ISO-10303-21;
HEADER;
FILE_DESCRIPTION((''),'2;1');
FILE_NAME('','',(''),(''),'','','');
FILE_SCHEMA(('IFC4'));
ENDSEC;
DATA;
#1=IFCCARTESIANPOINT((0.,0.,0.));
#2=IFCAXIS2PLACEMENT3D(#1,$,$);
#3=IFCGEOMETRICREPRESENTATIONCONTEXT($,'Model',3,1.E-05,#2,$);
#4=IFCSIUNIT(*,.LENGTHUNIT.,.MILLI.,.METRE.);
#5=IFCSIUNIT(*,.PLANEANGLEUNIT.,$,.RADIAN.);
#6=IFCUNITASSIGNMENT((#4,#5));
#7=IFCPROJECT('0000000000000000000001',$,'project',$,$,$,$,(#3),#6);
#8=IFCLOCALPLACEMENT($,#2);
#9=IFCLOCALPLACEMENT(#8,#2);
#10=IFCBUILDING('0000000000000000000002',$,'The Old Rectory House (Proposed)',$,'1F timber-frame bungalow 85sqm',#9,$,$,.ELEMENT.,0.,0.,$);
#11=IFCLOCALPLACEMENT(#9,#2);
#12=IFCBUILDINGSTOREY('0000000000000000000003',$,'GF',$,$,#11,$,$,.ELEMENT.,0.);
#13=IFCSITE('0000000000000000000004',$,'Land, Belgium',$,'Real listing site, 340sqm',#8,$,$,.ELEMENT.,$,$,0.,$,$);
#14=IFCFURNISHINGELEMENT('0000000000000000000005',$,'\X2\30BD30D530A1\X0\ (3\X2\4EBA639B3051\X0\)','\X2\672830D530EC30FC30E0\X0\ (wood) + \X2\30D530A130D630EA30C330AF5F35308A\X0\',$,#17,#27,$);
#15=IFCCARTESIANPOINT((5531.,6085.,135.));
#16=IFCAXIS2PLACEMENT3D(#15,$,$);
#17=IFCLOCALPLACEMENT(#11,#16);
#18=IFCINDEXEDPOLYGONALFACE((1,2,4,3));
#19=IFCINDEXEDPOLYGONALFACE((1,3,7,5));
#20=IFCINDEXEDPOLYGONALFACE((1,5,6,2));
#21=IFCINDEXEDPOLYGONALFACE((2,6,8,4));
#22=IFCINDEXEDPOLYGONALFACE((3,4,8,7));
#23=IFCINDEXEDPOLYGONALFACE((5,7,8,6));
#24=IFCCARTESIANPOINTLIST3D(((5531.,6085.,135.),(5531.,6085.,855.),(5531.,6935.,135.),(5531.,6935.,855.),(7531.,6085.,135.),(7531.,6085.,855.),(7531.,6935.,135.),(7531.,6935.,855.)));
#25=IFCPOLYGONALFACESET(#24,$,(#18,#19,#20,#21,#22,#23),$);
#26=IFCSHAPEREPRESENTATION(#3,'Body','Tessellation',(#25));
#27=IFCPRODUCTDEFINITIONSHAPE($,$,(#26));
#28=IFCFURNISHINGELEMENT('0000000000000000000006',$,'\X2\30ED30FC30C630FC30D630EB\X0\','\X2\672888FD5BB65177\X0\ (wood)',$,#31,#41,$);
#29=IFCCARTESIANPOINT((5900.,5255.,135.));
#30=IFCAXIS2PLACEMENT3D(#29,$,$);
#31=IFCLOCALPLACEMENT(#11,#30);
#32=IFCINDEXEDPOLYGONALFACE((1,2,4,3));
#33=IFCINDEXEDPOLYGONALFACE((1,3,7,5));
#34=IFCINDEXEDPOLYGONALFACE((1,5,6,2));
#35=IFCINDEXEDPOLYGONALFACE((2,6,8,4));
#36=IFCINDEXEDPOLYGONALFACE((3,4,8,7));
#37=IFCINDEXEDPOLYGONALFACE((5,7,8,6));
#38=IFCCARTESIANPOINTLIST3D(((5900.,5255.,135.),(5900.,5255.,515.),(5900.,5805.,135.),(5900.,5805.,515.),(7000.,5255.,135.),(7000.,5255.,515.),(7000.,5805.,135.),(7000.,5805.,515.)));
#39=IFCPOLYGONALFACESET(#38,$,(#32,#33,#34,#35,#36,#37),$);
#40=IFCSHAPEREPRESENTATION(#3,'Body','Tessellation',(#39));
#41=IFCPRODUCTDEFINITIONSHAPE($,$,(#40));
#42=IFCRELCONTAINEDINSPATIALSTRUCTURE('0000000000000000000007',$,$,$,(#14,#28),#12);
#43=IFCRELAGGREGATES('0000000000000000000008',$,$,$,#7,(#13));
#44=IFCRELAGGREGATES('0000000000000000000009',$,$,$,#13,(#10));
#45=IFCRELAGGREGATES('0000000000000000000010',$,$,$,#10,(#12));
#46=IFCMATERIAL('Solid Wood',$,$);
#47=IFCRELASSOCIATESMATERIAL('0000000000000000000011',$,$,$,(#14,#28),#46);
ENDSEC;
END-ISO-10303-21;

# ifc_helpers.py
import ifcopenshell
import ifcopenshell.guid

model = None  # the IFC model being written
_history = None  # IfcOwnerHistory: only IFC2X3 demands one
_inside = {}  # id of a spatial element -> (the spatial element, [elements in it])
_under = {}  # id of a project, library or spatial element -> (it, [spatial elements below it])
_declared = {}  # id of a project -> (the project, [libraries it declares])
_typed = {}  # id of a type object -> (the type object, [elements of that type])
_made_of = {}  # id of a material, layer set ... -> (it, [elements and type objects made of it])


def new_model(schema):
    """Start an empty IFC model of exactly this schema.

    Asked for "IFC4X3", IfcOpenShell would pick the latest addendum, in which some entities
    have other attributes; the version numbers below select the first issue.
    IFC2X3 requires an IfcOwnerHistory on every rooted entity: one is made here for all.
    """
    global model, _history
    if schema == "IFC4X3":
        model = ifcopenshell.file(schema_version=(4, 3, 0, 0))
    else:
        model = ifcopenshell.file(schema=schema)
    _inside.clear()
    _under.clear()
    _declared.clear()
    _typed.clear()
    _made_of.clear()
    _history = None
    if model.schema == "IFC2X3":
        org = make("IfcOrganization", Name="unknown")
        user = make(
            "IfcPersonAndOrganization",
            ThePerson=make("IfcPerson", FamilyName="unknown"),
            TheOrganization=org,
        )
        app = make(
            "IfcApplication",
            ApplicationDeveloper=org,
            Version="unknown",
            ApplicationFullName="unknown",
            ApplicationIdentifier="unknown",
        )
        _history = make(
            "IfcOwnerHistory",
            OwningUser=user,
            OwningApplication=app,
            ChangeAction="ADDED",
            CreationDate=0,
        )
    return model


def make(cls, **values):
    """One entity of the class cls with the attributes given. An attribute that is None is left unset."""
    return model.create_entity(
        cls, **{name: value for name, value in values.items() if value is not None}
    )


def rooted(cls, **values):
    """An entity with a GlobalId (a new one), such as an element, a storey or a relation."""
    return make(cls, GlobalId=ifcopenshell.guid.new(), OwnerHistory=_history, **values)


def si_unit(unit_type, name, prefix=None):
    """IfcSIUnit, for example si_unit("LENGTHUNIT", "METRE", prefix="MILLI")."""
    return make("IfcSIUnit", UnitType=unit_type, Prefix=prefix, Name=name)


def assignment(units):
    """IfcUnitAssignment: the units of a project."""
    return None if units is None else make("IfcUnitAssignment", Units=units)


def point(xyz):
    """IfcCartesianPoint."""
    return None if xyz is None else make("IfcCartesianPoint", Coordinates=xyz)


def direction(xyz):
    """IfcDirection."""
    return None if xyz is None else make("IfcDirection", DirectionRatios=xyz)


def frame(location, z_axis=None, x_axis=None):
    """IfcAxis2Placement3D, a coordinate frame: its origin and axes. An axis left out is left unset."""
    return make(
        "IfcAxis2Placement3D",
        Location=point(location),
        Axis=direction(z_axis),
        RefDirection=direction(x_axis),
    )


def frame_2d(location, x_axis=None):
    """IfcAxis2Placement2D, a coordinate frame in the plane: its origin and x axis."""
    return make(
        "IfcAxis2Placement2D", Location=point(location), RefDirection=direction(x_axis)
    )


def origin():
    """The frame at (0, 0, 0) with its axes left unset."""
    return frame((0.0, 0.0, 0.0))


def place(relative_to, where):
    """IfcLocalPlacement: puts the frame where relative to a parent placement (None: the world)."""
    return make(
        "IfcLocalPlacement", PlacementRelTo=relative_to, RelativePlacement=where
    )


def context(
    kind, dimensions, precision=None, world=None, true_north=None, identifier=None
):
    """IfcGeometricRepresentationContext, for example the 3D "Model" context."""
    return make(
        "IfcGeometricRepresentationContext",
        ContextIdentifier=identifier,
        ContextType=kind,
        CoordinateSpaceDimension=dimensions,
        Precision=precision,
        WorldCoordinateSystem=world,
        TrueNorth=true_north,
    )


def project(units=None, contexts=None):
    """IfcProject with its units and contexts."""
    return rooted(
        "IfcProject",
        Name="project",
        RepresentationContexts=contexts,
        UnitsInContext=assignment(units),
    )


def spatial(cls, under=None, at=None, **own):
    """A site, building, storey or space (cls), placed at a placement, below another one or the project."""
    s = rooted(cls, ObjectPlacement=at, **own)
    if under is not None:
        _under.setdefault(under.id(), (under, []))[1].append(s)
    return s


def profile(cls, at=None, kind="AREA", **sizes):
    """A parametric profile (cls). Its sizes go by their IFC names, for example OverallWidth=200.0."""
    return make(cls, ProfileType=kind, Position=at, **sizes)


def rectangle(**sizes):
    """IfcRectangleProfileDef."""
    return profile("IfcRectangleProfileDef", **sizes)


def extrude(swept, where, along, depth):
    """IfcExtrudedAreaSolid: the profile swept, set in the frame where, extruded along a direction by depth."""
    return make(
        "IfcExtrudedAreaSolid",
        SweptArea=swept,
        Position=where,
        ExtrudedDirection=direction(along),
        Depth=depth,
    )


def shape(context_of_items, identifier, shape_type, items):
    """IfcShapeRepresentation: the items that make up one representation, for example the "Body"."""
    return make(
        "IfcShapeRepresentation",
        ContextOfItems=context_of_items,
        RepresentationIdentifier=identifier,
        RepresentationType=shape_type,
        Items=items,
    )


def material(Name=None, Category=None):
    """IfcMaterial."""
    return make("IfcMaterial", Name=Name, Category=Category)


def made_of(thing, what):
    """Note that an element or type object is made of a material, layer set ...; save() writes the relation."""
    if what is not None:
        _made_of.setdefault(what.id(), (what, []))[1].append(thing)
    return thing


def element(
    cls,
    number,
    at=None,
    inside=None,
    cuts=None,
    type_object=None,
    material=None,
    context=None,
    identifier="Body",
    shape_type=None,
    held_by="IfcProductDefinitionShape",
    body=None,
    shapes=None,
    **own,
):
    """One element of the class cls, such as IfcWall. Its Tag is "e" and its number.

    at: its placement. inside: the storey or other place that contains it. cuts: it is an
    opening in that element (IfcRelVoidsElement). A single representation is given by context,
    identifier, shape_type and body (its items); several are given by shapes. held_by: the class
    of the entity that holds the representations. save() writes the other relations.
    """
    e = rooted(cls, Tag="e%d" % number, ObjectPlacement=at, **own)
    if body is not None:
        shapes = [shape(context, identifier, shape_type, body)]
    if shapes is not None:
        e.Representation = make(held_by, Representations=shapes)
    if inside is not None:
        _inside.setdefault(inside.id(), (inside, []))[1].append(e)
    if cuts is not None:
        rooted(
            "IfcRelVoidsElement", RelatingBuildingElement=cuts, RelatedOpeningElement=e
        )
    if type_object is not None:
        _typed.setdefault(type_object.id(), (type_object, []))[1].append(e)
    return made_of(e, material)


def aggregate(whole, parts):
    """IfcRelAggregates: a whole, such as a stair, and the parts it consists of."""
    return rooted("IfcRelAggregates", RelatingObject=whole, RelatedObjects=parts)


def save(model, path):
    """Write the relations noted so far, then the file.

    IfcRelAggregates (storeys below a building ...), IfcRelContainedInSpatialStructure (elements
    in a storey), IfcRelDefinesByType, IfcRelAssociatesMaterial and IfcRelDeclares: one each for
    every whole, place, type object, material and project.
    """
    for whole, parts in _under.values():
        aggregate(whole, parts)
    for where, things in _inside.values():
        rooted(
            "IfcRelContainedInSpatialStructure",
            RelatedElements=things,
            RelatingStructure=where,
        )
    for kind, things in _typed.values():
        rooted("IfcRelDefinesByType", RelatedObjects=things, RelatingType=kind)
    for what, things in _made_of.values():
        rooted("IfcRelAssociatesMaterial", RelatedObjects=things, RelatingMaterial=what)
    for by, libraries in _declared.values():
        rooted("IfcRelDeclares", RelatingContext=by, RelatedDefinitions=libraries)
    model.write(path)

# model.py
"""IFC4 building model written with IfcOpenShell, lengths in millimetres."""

from ifc_helpers import new_model, si_unit, frame, frame_2d, origin, place, context, project, spatial, rectangle, extrude, material, element, save


model = new_model("IFC4")

# Units and contexts
model_context = context("Model", 3, precision=1e-05, world=origin())
ifc_project = project(units=[si_unit("LENGTHUNIT", "METRE", prefix="MILLI"), si_unit("PLANEANGLEUNIT", "RADIAN")], contexts=[model_context])

# Site, building, storey
site_placement = place(None, origin())
site = spatial("IfcSite", under=ifc_project, at=site_placement, Name="Land, Belgium", ObjectType="Real listing site, 340sqm", CompositionType="ELEMENT", RefElevation=0.0)
building_placement = place(site_placement, origin())
building = spatial("IfcBuilding", under=site, at=building_placement, Name="The Old Rectory House (Proposed)", ObjectType="1F timber-frame bungalow 85sqm", CompositionType="ELEMENT", ElevationOfRefHeight=0.0, ElevationOfTerrain=0.0)
storey_placement = place(building_placement, origin())
storey = spatial("IfcBuildingStorey", under=building, at=storey_placement, Name="GF", CompositionType="ELEMENT", Elevation=0.0)

# Shared definitions
ifc_material_1 = material(Name="Solid Wood")

# Furnishing elements
furnishing_1_placement = place(storey_placement, frame((5531.0, 6085.0, 135.0)))
element("IfcFurnishingElement", 1, at=furnishing_1_placement, inside=storey, material=ifc_material_1, Name="ソファ (3人掛け)", Description="木フレーム (wood) + ファブリック張り", context=model_context, shape_type="SweptSolid", body=[
    extrude(rectangle(XDim=2000.0, YDim=850.0, at=frame_2d((1000.0, 425.0))), frame((5531.0, 6085.0, 135.0)), (0.0, 0.0, 1.0), 720.0),
])
furnishing_2_placement = place(storey_placement, frame((5900.0, 5255.0, 135.0)))
element("IfcFurnishingElement", 2, at=furnishing_2_placement, inside=storey, material=ifc_material_1, Name="ローテーブル", Description="木製家具 (wood)", context=model_context, shape_type="SweptSolid", body=[
    extrude(rectangle(XDim=1100.0, YDim=550.0, at=frame_2d((550.0, 275.0))), frame((5900.0, 5255.0, 135.0)), (0.0, 0.0, 1.0), 380.0),
])

save(model, "model.ifc")
